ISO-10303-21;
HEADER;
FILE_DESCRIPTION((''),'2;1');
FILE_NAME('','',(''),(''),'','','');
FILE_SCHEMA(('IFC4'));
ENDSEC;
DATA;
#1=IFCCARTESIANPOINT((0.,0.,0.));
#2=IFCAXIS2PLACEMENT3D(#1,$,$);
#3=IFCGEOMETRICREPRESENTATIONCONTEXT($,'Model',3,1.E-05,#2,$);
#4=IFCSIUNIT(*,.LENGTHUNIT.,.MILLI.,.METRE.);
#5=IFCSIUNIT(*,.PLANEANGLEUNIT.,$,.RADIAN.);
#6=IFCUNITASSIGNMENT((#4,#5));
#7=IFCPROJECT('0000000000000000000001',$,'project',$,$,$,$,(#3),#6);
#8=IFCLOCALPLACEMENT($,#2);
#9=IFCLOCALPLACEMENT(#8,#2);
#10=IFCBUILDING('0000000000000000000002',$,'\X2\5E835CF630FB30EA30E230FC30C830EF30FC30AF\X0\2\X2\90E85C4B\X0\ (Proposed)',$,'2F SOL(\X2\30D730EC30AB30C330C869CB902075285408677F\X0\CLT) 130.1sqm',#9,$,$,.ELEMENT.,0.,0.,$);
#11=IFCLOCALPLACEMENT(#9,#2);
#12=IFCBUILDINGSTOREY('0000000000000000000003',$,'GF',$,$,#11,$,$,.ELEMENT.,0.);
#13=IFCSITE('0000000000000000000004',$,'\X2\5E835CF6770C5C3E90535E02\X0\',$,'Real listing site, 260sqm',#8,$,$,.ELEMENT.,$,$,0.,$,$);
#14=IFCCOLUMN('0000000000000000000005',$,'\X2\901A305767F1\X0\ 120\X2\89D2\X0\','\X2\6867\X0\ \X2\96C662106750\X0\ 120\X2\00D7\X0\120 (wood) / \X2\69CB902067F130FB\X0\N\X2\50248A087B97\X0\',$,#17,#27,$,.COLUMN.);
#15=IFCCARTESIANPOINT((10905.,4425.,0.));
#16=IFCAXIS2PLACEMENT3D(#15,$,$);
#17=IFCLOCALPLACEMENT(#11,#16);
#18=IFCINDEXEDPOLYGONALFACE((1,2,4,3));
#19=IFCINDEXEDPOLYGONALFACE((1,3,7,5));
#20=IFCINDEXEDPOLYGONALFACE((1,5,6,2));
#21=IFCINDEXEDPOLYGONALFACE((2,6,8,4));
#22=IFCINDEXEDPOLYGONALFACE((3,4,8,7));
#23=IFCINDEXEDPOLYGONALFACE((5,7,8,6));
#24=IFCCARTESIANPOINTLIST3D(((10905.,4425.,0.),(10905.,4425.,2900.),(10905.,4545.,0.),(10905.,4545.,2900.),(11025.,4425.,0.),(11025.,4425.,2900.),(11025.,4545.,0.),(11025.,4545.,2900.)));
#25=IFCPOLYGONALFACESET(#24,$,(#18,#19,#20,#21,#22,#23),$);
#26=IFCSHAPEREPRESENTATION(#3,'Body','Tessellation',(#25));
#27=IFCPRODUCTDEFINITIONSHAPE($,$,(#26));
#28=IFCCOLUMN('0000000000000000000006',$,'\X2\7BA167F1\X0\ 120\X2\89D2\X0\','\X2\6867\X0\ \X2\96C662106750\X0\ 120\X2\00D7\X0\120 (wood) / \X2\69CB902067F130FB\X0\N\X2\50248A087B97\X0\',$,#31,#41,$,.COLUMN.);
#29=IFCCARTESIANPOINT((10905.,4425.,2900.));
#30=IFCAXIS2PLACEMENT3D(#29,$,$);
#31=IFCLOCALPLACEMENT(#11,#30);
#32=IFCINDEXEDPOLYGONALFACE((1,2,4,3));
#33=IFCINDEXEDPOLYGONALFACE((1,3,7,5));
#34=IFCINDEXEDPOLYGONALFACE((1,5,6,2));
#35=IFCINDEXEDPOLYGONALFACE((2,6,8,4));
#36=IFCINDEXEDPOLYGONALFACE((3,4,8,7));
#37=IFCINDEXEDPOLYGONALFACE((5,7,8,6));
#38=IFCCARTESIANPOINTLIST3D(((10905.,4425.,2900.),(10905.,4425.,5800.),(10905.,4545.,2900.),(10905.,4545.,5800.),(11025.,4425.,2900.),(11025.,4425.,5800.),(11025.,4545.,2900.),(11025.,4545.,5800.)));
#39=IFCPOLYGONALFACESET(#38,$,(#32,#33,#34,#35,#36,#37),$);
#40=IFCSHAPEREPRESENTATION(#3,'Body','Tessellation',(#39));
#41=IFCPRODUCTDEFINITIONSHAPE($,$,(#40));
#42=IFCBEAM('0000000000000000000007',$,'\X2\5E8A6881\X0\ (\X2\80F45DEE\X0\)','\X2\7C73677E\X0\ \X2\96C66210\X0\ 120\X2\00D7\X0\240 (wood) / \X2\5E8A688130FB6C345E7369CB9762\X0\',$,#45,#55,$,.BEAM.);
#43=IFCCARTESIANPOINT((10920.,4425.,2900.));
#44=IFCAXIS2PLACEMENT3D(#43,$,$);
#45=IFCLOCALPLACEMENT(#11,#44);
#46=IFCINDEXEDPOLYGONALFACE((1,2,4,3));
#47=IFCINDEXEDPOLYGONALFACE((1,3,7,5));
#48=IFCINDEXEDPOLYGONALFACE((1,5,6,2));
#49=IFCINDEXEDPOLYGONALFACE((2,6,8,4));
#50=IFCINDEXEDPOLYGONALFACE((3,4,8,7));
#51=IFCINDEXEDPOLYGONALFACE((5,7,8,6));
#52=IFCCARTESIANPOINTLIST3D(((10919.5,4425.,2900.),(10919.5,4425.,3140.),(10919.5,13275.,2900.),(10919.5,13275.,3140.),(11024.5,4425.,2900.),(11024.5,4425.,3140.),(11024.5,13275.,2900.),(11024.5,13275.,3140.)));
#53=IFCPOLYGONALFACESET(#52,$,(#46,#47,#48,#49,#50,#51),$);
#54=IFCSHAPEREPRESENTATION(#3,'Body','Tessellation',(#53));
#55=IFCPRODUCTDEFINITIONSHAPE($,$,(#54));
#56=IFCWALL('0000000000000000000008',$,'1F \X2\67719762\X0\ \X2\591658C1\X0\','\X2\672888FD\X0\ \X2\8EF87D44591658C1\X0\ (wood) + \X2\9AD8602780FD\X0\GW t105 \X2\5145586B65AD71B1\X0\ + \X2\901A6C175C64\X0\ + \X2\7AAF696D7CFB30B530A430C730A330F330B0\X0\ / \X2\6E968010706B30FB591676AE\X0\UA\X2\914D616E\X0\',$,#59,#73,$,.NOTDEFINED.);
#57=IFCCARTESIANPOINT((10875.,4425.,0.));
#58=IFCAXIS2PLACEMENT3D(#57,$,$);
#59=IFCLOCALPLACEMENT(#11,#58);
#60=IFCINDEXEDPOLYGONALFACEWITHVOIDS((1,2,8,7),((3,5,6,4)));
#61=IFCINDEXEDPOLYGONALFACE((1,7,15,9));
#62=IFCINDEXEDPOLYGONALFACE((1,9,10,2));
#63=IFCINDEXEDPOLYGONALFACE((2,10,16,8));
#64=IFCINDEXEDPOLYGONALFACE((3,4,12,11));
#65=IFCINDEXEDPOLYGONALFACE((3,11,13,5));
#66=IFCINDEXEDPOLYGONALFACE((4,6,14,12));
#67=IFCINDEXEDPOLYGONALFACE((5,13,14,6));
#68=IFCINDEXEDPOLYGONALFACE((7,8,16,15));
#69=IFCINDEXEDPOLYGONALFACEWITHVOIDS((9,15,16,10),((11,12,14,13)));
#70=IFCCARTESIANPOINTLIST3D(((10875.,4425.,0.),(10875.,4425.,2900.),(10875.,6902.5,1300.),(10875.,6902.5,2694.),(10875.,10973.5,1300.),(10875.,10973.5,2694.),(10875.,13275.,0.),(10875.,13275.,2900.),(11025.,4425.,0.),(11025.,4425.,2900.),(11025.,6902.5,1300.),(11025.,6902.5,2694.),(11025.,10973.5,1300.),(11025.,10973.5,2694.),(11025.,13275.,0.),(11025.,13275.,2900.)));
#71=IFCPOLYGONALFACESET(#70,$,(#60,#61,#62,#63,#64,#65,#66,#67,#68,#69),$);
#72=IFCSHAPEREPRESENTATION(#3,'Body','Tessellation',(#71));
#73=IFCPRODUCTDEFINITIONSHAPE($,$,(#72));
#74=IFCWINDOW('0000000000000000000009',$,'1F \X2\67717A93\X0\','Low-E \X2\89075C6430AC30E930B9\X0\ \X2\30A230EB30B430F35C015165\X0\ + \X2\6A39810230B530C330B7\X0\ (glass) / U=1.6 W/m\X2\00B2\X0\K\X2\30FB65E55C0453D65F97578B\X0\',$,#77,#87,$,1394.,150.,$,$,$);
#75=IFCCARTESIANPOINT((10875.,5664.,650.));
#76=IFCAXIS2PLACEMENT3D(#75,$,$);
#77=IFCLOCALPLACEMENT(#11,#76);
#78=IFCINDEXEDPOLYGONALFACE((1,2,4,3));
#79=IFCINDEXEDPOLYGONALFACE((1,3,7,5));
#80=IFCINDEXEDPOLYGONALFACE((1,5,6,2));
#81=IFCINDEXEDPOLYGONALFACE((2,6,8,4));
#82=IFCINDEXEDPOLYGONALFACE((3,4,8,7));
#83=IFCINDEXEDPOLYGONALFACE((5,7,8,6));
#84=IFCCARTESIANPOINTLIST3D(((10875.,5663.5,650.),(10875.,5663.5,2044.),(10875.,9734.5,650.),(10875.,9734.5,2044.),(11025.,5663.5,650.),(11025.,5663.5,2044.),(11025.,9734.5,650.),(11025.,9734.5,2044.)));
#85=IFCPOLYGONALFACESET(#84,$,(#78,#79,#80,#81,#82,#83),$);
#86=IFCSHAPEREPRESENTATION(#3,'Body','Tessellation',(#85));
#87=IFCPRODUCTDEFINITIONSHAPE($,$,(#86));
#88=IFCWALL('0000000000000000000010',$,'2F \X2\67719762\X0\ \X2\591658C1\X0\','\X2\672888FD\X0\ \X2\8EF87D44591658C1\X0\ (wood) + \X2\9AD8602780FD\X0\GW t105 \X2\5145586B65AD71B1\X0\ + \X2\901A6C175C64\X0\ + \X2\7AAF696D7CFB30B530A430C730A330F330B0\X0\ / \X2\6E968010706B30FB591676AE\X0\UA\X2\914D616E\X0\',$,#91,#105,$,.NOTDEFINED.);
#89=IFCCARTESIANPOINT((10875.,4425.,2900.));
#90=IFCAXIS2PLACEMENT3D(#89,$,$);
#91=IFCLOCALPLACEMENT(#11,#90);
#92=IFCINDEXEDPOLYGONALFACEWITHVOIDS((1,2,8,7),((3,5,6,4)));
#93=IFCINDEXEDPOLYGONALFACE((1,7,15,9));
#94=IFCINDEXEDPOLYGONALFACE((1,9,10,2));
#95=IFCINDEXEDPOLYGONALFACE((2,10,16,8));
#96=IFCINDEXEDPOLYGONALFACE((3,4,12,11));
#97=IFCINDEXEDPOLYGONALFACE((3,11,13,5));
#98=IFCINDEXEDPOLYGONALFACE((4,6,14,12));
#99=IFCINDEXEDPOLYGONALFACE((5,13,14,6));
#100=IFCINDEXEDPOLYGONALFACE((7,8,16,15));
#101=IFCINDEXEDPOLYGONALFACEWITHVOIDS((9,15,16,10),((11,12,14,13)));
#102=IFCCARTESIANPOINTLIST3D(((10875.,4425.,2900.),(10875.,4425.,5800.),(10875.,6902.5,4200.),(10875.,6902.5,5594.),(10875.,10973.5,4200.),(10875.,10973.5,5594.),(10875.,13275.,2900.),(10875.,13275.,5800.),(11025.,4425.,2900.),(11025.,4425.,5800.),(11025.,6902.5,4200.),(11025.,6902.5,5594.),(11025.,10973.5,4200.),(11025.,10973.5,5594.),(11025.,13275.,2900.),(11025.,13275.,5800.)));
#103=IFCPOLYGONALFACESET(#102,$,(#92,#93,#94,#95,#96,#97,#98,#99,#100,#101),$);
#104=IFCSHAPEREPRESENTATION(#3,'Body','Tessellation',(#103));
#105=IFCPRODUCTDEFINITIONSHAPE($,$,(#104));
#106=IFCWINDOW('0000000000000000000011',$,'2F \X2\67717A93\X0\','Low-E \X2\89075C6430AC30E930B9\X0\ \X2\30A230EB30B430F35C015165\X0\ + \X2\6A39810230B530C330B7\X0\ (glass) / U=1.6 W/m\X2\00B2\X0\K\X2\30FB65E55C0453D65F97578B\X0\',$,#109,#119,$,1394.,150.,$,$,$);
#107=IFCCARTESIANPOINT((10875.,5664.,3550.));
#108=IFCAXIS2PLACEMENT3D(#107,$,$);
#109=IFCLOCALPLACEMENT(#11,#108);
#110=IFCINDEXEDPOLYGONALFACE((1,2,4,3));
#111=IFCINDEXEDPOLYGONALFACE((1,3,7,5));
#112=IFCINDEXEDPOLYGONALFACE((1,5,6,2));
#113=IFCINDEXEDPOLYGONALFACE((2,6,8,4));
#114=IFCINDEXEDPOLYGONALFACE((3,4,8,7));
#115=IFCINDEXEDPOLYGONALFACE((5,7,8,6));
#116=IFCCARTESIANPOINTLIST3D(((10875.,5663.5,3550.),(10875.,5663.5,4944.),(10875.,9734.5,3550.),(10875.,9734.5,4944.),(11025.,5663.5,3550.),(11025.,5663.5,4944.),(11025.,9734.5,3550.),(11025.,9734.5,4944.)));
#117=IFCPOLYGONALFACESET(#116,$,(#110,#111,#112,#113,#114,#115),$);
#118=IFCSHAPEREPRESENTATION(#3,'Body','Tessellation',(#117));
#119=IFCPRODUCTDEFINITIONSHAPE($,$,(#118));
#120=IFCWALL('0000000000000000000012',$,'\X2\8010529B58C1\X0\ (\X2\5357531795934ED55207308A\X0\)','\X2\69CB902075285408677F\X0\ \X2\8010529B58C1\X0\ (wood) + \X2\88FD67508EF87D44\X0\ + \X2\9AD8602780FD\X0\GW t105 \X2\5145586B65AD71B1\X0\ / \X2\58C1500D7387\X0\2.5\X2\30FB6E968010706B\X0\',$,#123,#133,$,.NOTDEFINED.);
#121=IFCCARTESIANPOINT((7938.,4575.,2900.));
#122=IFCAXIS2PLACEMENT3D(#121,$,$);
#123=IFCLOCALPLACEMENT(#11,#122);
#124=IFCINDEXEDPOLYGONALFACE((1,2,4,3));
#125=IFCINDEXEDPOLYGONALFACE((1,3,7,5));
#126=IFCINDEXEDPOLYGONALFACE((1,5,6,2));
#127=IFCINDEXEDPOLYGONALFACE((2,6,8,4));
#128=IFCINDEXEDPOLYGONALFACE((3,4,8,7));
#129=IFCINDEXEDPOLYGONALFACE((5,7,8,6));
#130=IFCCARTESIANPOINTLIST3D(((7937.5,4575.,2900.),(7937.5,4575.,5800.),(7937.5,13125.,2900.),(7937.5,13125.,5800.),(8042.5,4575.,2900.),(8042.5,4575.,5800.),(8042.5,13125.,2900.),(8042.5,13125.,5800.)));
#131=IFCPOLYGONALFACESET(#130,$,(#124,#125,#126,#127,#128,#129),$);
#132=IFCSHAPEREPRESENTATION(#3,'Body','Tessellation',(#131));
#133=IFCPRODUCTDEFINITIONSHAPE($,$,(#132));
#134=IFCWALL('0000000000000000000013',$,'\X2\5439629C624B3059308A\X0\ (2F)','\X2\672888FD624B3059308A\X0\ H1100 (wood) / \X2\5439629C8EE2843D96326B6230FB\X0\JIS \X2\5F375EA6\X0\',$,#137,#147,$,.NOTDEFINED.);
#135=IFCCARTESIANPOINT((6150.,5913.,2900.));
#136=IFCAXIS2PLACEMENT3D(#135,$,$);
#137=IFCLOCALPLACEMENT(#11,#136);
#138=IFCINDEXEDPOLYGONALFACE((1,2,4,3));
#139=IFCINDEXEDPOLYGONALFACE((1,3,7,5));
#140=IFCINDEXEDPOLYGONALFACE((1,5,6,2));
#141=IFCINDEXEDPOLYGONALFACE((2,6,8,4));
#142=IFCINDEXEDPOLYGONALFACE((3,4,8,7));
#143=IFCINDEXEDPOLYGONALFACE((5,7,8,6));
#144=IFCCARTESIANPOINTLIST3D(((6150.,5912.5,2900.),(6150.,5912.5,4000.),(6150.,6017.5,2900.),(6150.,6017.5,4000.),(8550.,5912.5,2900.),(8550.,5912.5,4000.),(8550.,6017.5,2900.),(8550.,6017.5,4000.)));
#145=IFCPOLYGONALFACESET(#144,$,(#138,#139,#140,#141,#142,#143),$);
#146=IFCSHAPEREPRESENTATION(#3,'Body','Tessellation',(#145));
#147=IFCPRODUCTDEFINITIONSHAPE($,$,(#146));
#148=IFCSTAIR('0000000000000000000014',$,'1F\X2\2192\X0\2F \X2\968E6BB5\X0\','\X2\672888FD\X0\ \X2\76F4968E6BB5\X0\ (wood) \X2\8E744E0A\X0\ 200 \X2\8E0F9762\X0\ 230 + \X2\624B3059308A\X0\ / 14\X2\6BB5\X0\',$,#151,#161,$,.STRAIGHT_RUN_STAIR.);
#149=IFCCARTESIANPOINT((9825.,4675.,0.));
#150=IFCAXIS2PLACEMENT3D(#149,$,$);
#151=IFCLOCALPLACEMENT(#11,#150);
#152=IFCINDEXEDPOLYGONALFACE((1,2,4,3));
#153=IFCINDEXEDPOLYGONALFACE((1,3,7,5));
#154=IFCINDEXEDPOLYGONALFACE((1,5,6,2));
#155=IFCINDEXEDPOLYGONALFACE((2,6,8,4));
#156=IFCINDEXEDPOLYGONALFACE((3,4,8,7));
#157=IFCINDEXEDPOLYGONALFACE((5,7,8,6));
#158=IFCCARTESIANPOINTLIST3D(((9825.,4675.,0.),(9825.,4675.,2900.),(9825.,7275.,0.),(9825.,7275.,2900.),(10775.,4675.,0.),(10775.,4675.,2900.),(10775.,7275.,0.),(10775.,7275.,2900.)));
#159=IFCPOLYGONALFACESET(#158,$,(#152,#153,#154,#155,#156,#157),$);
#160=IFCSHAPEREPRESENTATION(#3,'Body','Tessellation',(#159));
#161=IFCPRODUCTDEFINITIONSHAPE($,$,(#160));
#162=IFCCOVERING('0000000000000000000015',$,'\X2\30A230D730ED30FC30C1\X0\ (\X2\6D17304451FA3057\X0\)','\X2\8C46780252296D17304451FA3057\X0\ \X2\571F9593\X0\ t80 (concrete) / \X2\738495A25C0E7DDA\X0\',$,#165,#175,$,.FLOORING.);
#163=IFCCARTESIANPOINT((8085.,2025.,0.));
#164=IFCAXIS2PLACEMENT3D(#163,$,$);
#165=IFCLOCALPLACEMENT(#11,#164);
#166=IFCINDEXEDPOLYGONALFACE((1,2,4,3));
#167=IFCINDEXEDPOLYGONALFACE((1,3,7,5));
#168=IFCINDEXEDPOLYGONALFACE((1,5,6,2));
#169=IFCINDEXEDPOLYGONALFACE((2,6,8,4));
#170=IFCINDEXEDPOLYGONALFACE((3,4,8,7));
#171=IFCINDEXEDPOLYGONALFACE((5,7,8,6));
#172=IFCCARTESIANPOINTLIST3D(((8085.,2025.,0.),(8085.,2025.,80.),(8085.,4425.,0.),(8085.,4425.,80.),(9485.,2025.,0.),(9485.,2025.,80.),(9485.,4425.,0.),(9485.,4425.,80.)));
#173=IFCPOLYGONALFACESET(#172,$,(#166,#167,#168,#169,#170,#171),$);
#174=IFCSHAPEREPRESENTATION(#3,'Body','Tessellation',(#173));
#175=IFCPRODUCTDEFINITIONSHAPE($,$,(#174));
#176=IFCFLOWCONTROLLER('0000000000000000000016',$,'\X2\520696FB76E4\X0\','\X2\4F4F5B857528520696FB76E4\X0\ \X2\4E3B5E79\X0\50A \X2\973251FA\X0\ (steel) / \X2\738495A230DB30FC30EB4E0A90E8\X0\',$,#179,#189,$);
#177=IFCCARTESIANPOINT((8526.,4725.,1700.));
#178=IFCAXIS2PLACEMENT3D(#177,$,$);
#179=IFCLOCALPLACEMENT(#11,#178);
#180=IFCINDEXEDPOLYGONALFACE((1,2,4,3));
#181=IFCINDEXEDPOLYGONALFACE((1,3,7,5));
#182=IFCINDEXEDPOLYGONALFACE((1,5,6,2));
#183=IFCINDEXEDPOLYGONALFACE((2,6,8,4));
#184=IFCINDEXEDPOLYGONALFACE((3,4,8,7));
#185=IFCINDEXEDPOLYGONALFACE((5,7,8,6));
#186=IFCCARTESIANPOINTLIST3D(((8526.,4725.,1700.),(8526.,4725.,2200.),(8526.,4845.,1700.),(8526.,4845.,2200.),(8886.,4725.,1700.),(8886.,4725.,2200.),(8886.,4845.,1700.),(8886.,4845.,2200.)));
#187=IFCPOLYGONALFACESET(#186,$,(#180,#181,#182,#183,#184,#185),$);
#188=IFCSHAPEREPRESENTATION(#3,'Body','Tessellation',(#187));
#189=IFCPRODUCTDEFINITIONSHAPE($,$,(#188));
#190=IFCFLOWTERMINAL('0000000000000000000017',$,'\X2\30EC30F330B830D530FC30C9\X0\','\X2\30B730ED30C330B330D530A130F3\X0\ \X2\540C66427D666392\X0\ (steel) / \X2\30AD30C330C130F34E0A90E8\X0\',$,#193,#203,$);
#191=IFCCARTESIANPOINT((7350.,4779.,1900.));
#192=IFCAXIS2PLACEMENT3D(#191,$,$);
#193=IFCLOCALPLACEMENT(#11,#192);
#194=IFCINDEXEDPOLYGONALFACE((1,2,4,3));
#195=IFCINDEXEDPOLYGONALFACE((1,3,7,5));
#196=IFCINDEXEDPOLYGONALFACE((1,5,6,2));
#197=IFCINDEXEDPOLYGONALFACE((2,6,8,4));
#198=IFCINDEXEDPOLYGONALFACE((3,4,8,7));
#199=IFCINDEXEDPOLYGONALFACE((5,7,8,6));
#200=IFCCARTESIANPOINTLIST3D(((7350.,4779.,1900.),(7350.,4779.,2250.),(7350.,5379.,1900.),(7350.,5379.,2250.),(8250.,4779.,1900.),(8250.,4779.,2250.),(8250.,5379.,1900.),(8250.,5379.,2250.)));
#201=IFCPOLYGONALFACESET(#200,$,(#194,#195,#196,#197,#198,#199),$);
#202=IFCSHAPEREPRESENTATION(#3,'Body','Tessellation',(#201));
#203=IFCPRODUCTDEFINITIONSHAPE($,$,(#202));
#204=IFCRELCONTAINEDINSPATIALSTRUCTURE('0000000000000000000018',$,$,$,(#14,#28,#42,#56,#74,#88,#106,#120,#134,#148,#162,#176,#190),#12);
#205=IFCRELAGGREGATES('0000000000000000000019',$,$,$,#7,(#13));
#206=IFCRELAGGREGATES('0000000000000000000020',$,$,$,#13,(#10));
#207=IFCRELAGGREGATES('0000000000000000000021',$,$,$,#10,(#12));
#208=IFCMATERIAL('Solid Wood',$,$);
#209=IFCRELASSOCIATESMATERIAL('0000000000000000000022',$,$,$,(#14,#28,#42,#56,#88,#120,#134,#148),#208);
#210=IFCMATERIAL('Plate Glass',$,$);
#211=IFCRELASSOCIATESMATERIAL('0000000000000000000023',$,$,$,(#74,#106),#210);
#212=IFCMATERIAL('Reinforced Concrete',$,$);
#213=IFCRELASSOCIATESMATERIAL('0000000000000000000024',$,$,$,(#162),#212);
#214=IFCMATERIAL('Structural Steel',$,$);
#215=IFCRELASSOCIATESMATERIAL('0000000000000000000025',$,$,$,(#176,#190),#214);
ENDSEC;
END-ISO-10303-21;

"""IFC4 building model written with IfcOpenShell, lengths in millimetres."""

from ifc_helpers import new_model, si_unit, frame, frame_2d, origin, place, context, project, spatial, rectangle, extrude, material, element, fill, save


model = new_model("IFC4")

# Units and contexts
model_context = context("Model", 3, precision=1e-05, world=origin())
ifc_project = project(units=[si_unit("LENGTHUNIT", "METRE", prefix="MILLI"), si_unit("PLANEANGLEUNIT", "RADIAN")], contexts=[model_context])

# Site, building, storey
site_placement = place(None, origin())
site = spatial("IfcSite", under=ifc_project, at=site_placement, Name="広島県尾道市", ObjectType="Real listing site, 260sqm", CompositionType="ELEMENT", RefElevation=0.0)
building_placement = place(site_placement, origin())
building = spatial("IfcBuilding", under=site, at=building_placement, Name="広島・リモートワーク2部屋 (Proposed)", ObjectType="2F SOL(プレカット構造用合板CLT) 130.1sqm", CompositionType="ELEMENT", ElevationOfRefHeight=0.0, ElevationOfTerrain=0.0)
storey_placement = place(building_placement, origin())
storey = spatial("IfcBuildingStorey", under=building, at=storey_placement, Name="GF", CompositionType="ELEMENT", Elevation=0.0)

# Columns
ifc_material_1 = material(Name="Solid Wood")
column_1_placement = place(storey_placement, frame((10905.0, 4425.0, 0.0)))
element("IfcColumn", 1, at=column_1_placement, inside=storey, material=ifc_material_1, Name="通し柱 120角", Description="桧 集成材 120×120 (wood) / 構造柱・N値計算", PredefinedType="COLUMN", context=model_context, shape_type="SweptSolid", body=[
    extrude(rectangle(XDim=120.0, YDim=120.0, at=frame_2d((60.0, 60.0))), frame((10905.0, 4425.0, 0.0)), (0.0, 0.0, 1.0), 2900.0),
])
column_2_placement = place(storey_placement, frame((10905.0, 4425.0, 2900.0)))
element("IfcColumn", 2, at=column_2_placement, inside=storey, material=ifc_material_1, Name="管柱 120角", Description="桧 集成材 120×120 (wood) / 構造柱・N値計算", PredefinedType="COLUMN", context=model_context, shape_type="SweptSolid", body=[
    extrude(rectangle(XDim=120.0, YDim=120.0, at=frame_2d((60.0, 60.0))), frame((10905.0, 4425.0, 2900.0)), (0.0, 0.0, 1.0), 2900.0),
])

# Beam
beam_1_placement = place(storey_placement, frame((10920.0, 4425.0, 2900.0)))
element("IfcBeam", 3, at=beam_1_placement, inside=storey, material=ifc_material_1, Name="床梁 (胴差)", Description="米松 集成 120×240 (wood) / 床梁・水平構面", PredefinedType="BEAM", context=model_context, shape_type="SweptSolid", body=[
    extrude(rectangle(XDim=105.0, YDim=8850.0, at=frame_2d((52.0, 4425.0))), frame((10920.0, 4425.0, 2900.0)), (0.0, 0.0, 1.0), 240.0),
])

# Wall, opening, window
wall_1_placement = place(storey_placement, frame((10875.0, 4425.0, 0.0)))
wall_1 = element("IfcWall", 4, at=wall_1_placement, inside=storey, material=ifc_material_1, Name="1F 東面 外壁", Description="木製 軸組外壁 (wood) + 高性能GW t105 充填断熱 + 通気層 + 窯業系サイディング / 準耐火・外皮UA配慮", PredefinedType="NOTDEFINED", context=model_context, shape_type="SweptSolid", body=[
    extrude(rectangle(XDim=150.0, YDim=8850.0, at=frame_2d((75.0, 4425.0))), frame((10875.0, 4425.0, 0.0)), (0.0, 0.0, 1.0), 2900.0),
])
opening_1_placement = place(storey_placement, frame((10875.0, 5664.0, 650.0)))
opening_1 = element("IfcOpeningElement", 5, at=opening_1_placement, cuts=wall_1, PredefinedType="NOTDEFINED", context=model_context, shape_type="SweptSolid", body=[
    extrude(rectangle(XDim=150.0, YDim=4071.0, at=frame_2d((75.0, 2035.0))), frame((10875.0, 5664.0, 650.0)), (0.0, 0.0, 1.0), 1394.0),
])
ifc_material_2 = material(Name="Plate Glass")
window_1_placement = place(storey_placement, frame((10875.0, 5664.0, 650.0)))
window_1 = element("IfcWindow", 6, at=window_1_placement, inside=storey, material=ifc_material_2, Name="1F 東窓", Description="Low-E 複層ガラス アルゴン封入 + 樹脂サッシ (glass) / U=1.6 W/m²K・日射取得型", OverallHeight=1394.0, OverallWidth=150.0, context=model_context, shape_type="SweptSolid", body=[
    extrude(rectangle(XDim=150.0, YDim=4071.0, at=frame_2d((75.0, 2035.0))), frame((10875.0, 5664.0, 650.0)), (0.0, 0.0, 1.0), 1394.0),
])
fill(opening_1, window_1)

# Wall, opening, window
wall_2_placement = place(storey_placement, frame((10875.0, 4425.0, 2900.0)))
wall_2 = element("IfcWall", 7, at=wall_2_placement, inside=storey, material=ifc_material_1, Name="2F 東面 外壁", Description="木製 軸組外壁 (wood) + 高性能GW t105 充填断熱 + 通気層 + 窯業系サイディング / 準耐火・外皮UA配慮", PredefinedType="NOTDEFINED", context=model_context, shape_type="SweptSolid", body=[
    extrude(rectangle(XDim=150.0, YDim=8850.0, at=frame_2d((75.0, 4425.0))), frame((10875.0, 4425.0, 2900.0)), (0.0, 0.0, 1.0), 2900.0),
])
opening_2_placement = place(storey_placement, frame((10875.0, 5664.0, 3550.0)))
opening_2 = element("IfcOpeningElement", 8, at=opening_2_placement, cuts=wall_2, PredefinedType="NOTDEFINED", context=model_context, shape_type="SweptSolid", body=[
    extrude(rectangle(XDim=150.0, YDim=4071.0, at=frame_2d((75.0, 2035.0))), frame((10875.0, 5664.0, 3550.0)), (0.0, 0.0, 1.0), 1394.0),
])
window_2_placement = place(storey_placement, frame((10875.0, 5664.0, 3550.0)))
window_2 = element("IfcWindow", 9, at=window_2_placement, inside=storey, material=ifc_material_2, Name="2F 東窓", Description="Low-E 複層ガラス アルゴン封入 + 樹脂サッシ (glass) / U=1.6 W/m²K・日射取得型", OverallHeight=1394.0, OverallWidth=150.0, context=model_context, shape_type="SweptSolid", body=[
    extrude(rectangle(XDim=150.0, YDim=4071.0, at=frame_2d((75.0, 2035.0))), frame((10875.0, 5664.0, 3550.0)), (0.0, 0.0, 1.0), 1394.0),
])
fill(opening_2, window_2)

# Walls
wall_3_placement = place(storey_placement, frame((7938.0, 4575.0, 2900.0)))
element("IfcWall", 10, at=wall_3_placement, inside=storey, material=ifc_material_1, Name="耐力壁 (南北間仕切り)", Description="構造用合板 耐力壁 (wood) + 製材軸組 + 高性能GW t105 充填断熱 / 壁倍率2.5・準耐火", PredefinedType="NOTDEFINED", context=model_context, shape_type="SweptSolid", body=[
    extrude(rectangle(XDim=105.0, YDim=8550.0, at=frame_2d((52.0, 4275.0))), frame((7938.0, 4575.0, 2900.0)), (0.0, 0.0, 1.0), 2900.0),
])
wall_4_placement = place(storey_placement, frame((6150.0, 5913.0, 2900.0)))
element("IfcWall", 11, at=wall_4_placement, inside=storey, material=ifc_material_1, Name="吹抜手すり (2F)", Description="木製手すり H1100 (wood) / 吹抜転落防止・JIS 強度", PredefinedType="NOTDEFINED", context=model_context, shape_type="SweptSolid", body=[
    extrude(rectangle(XDim=2400.0, YDim=105.0, at=frame_2d((1200.0, 52.0))), frame((6150.0, 5913.0, 2900.0)), (0.0, 0.0, 1.0), 1100.0),
])

# Stair
stair_placement = place(storey_placement, frame((9825.0, 4675.0, 0.0)))
element("IfcStair", 12, at=stair_placement, inside=storey, material=ifc_material_1, Name="1F→2F 階段", Description="木製 直階段 (wood) 蹴上 200 踏面 230 + 手すり / 14段", PredefinedType="STRAIGHT_RUN_STAIR", context=model_context, shape_type="SweptSolid", body=[
    extrude(rectangle(XDim=950.0, YDim=2600.0, at=frame_2d((475.0, 1300.0))), frame((9825.0, 4675.0, 0.0)), (0.0, 0.0, 1.0), 2900.0),
])

# Covering
ifc_material_3 = material(Name="Reinforced Concrete")
covering_placement = place(storey_placement, frame((8085.0, 2025.0, 0.0)))
element("IfcCovering", 13, at=covering_placement, inside=storey, material=ifc_material_3, Name="アプローチ (洗い出し)", Description="豆砂利洗い出し 土間 t80 (concrete) / 玄関導線", PredefinedType="FLOORING", context=model_context, shape_type="SweptSolid", body=[
    extrude(rectangle(XDim=1400.0, YDim=2400.0, at=frame_2d((700.0, 1200.0))), frame((8085.0, 2025.0, 0.0)), (0.0, 0.0, 1.0), 80.0),
])

# Flow controller
ifc_material_4 = material(Name="Structural Steel")
flow_controller_placement = place(storey_placement, frame((8526.0, 4725.0, 1700.0)))
element("IfcFlowController", 14, at=flow_controller_placement, inside=storey, material=ifc_material_4, Name="分電盤", Description="住宅用分電盤 主幹50A 露出 (steel) / 玄関ホール上部", context=model_context, shape_type="SweptSolid", body=[
    extrude(rectangle(XDim=360.0, YDim=120.0, at=frame_2d((180.0, 60.0))), frame((8526.0, 4725.0, 1700.0)), (0.0, 0.0, 1.0), 500.0),
])

# Flow terminal
flow_terminal_1_placement = place(storey_placement, frame((7350.0, 4779.0, 1900.0)))
element("IfcFlowTerminal", 15, at=flow_terminal_1_placement, inside=storey, material=ifc_material_4, Name="レンジフード", Description="シロッコファン 同時給排 (steel) / キッチン上部", context=model_context, shape_type="SweptSolid", body=[
    extrude(rectangle(XDim=900.0, YDim=600.0, at=frame_2d((450.0, 300.0))), frame((7350.0, 4779.0, 1900.0)), (0.0, 0.0, 1.0), 350.0),
])

save(model, "model.ifc")
